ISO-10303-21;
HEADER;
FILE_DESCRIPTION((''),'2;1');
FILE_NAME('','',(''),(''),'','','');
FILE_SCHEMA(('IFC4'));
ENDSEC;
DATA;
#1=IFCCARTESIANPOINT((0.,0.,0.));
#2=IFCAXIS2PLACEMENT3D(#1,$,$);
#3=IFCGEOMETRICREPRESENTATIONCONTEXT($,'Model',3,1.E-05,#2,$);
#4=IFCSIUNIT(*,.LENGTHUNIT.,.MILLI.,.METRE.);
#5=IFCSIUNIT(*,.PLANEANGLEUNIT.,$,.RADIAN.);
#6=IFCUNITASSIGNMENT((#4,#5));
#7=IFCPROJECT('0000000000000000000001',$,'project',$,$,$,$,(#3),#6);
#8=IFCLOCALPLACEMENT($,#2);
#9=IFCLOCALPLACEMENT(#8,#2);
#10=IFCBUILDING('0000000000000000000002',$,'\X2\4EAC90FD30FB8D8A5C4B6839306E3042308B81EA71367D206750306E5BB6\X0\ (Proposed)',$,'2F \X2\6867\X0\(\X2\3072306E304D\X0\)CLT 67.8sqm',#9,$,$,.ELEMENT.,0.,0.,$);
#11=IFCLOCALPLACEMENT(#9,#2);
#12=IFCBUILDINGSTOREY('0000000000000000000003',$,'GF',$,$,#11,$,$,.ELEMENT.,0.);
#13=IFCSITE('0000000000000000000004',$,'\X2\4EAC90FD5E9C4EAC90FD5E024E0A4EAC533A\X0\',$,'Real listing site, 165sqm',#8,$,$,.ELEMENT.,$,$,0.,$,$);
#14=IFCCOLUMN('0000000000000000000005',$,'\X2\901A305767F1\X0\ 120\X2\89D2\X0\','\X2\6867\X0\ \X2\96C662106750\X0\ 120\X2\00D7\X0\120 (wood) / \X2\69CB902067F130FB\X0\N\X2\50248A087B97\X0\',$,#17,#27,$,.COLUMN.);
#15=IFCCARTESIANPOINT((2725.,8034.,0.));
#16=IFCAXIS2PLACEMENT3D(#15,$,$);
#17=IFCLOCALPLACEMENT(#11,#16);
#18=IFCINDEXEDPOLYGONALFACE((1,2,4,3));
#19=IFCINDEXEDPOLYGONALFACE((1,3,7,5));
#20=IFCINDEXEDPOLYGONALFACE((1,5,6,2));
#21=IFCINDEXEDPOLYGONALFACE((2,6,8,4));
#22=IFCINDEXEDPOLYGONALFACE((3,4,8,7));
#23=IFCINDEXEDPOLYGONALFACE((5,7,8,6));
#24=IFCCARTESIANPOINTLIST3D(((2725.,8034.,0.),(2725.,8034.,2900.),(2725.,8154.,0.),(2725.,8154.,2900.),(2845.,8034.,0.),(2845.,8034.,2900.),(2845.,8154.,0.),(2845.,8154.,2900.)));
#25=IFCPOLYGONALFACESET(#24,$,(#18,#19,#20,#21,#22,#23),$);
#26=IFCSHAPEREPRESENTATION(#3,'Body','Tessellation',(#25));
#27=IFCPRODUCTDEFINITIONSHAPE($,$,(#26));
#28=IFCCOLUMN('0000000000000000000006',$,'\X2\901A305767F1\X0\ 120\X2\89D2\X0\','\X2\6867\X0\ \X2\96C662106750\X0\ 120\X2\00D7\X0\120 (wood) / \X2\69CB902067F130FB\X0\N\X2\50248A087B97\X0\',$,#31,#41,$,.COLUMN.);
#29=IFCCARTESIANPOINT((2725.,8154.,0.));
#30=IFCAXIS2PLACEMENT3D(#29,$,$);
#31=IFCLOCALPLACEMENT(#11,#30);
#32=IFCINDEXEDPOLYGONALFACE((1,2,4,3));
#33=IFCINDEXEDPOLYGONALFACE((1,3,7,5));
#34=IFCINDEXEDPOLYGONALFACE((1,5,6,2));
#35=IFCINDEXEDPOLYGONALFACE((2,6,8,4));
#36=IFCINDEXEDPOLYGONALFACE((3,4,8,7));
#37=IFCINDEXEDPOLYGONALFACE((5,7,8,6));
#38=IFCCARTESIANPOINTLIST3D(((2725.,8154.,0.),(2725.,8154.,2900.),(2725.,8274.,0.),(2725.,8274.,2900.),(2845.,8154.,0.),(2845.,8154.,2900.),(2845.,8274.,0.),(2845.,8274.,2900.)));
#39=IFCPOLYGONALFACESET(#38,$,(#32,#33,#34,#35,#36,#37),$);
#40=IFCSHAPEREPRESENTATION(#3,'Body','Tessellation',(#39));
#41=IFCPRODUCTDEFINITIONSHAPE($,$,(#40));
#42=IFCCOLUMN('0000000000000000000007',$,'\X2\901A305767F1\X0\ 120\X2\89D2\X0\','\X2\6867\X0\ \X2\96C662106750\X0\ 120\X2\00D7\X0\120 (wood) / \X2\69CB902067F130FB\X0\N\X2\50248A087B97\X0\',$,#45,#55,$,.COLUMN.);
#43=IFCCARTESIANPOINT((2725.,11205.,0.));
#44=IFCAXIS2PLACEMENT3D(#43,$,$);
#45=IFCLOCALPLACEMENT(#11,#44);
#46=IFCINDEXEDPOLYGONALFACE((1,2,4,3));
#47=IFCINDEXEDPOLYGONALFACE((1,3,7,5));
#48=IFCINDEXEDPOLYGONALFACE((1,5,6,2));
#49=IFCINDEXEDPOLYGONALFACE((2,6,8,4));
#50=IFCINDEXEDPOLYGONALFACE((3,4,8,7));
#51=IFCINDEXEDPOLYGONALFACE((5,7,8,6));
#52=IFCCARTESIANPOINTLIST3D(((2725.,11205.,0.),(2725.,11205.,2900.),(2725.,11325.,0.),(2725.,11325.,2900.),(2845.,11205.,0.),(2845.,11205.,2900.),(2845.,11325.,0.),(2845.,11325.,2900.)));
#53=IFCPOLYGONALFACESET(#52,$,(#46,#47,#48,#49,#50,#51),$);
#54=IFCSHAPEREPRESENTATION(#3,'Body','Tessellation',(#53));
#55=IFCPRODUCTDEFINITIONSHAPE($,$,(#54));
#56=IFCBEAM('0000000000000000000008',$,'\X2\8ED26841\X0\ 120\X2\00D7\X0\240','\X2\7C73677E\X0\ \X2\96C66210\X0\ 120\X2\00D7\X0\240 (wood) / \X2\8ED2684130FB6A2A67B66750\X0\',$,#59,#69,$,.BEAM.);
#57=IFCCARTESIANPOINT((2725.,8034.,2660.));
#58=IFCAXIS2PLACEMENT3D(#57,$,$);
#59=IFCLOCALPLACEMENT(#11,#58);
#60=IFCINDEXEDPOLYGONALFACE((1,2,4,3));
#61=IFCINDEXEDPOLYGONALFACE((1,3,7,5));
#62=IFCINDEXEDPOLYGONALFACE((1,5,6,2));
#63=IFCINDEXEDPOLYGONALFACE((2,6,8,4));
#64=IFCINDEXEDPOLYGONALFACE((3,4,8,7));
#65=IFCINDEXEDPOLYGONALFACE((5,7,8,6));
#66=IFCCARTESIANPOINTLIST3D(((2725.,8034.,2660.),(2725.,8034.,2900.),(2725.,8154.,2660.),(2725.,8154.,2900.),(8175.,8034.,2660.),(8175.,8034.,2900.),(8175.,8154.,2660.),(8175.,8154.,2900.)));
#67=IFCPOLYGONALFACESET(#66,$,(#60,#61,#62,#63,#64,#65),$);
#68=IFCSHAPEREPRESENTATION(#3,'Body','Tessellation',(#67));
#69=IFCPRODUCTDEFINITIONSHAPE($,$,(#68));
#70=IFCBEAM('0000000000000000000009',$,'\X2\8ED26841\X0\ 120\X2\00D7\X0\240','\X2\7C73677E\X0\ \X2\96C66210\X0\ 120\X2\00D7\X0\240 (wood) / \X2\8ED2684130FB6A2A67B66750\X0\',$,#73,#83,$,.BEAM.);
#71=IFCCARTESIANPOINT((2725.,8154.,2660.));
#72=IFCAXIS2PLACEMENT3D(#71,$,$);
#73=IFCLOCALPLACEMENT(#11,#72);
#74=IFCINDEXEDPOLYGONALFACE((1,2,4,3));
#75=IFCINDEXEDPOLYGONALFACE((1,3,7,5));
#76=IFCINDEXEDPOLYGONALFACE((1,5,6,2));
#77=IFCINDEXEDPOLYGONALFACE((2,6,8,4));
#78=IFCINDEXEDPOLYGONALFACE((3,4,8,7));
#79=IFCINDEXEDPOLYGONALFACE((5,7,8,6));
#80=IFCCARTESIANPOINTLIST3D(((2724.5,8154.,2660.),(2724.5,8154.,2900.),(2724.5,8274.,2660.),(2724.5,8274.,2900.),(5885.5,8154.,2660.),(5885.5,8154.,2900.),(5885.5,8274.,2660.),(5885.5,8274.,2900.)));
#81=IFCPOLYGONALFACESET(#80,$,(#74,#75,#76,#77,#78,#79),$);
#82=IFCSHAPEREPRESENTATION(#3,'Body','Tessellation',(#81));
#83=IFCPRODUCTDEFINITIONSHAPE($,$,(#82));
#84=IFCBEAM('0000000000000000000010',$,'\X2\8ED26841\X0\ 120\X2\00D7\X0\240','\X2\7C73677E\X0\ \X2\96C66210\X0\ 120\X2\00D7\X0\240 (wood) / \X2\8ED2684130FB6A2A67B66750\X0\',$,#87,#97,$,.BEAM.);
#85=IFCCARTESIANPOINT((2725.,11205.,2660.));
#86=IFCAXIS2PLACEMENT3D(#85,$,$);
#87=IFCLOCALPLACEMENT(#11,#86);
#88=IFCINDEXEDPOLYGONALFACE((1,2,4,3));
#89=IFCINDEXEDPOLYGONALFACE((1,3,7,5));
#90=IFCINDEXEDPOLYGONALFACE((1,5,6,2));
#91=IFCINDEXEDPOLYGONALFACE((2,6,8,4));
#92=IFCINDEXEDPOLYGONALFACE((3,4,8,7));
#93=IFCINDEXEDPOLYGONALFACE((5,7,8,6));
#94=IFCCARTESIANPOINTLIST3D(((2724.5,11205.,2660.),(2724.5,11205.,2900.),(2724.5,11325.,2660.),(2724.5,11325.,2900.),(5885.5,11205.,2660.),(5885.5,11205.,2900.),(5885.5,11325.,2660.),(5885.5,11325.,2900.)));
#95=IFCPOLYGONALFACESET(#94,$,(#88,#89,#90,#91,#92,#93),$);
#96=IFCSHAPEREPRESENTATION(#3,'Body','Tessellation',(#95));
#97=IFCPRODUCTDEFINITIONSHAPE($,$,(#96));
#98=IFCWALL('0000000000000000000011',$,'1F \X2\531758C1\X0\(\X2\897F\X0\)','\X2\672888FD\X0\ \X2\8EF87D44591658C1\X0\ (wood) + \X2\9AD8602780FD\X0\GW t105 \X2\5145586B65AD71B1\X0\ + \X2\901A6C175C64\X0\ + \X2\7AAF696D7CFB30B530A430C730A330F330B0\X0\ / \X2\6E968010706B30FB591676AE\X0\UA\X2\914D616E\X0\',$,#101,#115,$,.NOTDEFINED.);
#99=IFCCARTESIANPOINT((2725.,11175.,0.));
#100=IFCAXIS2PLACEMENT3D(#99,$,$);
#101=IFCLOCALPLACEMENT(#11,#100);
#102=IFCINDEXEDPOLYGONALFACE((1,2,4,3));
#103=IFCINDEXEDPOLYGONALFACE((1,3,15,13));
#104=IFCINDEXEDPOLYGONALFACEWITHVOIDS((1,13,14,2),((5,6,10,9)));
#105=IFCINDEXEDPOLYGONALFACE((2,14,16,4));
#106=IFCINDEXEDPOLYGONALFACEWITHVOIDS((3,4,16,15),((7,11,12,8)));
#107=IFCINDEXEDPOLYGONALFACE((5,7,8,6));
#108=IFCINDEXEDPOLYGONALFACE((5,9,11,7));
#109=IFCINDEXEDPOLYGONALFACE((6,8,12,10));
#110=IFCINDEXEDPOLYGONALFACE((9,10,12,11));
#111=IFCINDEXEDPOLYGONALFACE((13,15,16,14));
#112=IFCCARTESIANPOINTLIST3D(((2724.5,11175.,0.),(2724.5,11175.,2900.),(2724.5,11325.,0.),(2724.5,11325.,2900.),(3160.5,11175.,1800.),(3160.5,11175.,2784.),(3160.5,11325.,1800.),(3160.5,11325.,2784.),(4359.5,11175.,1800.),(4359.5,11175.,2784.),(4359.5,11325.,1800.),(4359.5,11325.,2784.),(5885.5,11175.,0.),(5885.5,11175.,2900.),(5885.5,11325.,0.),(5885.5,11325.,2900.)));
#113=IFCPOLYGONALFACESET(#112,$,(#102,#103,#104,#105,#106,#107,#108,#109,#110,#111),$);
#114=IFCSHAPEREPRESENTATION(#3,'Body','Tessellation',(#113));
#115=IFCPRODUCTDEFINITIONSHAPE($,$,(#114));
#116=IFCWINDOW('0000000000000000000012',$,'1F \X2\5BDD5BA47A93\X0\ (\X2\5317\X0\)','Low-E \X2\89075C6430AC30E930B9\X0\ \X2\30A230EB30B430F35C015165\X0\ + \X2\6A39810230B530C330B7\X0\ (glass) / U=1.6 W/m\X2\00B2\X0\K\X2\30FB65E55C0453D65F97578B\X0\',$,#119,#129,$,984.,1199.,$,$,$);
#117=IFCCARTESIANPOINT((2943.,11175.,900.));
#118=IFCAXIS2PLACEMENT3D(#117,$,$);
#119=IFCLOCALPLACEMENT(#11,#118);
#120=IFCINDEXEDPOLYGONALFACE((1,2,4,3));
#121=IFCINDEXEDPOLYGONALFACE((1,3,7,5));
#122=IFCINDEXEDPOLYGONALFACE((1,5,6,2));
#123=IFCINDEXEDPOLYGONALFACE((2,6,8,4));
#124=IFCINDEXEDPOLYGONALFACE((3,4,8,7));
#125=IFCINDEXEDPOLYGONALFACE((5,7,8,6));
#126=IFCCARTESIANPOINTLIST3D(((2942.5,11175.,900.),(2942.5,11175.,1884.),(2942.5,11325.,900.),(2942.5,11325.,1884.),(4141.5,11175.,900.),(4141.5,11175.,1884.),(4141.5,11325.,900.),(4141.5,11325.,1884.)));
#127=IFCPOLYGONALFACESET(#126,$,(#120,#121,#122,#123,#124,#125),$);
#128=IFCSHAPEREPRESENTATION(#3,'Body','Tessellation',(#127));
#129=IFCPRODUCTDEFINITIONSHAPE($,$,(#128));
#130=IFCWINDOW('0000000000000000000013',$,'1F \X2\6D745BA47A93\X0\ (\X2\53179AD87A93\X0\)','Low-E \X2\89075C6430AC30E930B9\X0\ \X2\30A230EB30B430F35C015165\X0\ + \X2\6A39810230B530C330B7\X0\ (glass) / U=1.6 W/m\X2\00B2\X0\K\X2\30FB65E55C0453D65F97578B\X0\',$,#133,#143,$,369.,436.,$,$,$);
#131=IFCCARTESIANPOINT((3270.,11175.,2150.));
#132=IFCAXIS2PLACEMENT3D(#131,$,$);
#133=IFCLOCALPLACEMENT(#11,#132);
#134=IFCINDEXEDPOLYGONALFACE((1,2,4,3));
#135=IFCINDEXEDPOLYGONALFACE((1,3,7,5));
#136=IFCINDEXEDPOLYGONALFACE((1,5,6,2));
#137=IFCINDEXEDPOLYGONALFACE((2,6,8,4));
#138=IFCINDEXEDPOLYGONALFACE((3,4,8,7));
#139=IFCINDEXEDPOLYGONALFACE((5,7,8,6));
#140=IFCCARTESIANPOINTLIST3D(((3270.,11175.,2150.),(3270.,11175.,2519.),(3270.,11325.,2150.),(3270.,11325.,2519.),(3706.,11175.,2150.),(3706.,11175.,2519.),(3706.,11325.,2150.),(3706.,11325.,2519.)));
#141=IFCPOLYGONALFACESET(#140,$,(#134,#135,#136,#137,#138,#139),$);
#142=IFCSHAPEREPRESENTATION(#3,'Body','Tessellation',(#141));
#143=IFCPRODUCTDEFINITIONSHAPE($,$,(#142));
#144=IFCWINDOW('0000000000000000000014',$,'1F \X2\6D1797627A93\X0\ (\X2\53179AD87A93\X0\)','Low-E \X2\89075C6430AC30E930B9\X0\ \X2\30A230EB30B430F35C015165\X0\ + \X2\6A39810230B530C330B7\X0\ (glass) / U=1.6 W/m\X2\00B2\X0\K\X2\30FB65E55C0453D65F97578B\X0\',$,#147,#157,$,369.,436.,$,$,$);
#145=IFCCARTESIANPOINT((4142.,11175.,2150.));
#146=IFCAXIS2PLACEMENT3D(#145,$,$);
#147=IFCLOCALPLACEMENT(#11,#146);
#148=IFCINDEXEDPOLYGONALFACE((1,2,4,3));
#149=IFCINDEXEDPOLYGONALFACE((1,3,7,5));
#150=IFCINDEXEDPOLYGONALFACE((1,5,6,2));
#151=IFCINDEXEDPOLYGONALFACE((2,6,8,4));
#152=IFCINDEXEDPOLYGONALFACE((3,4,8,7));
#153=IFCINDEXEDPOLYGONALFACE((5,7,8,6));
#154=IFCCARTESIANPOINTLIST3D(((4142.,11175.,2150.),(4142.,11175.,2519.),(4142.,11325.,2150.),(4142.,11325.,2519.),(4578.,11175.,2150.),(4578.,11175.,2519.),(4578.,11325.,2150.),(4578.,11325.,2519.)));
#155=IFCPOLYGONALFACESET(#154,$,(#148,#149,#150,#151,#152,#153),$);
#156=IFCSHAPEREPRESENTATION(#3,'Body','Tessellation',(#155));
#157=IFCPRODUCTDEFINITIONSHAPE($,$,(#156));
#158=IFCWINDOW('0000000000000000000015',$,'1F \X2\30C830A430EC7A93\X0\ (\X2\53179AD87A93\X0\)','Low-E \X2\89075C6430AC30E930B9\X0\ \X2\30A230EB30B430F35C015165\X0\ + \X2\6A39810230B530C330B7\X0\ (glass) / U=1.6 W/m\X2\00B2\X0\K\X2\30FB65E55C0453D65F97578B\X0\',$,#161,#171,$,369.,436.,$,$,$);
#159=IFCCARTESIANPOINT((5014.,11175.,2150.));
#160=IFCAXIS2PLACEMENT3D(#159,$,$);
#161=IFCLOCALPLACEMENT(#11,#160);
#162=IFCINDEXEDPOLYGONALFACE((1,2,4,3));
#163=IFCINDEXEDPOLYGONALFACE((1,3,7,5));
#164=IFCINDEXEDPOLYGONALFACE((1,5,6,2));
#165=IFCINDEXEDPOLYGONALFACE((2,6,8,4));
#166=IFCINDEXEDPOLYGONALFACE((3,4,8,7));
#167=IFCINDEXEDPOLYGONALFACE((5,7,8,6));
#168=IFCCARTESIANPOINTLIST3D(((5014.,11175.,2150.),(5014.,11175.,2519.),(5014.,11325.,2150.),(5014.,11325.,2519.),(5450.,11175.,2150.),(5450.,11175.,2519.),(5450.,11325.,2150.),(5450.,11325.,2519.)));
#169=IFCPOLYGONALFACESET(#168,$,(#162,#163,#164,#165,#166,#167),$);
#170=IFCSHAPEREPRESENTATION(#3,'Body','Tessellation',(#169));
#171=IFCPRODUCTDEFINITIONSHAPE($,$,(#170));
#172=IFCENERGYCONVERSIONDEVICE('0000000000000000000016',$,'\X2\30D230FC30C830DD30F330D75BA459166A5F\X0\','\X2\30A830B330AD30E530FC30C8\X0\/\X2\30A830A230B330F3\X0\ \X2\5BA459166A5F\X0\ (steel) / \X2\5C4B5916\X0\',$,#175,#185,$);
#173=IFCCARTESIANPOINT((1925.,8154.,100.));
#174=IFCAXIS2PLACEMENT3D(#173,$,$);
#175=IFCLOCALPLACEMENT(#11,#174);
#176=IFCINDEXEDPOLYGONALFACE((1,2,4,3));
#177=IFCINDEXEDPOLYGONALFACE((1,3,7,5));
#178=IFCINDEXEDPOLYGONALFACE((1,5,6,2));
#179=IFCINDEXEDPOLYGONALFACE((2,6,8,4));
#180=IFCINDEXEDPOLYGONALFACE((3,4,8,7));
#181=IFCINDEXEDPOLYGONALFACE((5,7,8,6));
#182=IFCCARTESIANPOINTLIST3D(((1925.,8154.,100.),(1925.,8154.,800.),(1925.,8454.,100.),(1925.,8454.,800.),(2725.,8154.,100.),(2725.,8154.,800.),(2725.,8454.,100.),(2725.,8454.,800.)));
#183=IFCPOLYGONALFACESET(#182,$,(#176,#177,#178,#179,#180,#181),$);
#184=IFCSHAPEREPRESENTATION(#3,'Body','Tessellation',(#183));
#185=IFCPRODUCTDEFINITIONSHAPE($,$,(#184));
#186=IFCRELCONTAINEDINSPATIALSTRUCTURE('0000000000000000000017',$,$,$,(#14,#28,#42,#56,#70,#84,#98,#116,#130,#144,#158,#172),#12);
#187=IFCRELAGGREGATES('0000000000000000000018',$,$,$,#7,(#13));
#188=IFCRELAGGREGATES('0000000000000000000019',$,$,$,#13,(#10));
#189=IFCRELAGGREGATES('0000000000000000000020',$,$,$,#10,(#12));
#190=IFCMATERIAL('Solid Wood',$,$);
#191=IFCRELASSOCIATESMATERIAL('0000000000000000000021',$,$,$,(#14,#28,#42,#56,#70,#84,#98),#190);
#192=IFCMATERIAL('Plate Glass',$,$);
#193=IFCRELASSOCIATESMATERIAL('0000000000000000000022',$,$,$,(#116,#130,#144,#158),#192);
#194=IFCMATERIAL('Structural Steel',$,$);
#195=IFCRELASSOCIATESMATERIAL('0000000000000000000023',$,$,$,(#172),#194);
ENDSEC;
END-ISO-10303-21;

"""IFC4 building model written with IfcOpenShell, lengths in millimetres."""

from ifc_helpers import new_model, si_unit, frame, frame_2d, origin, place, context, project, spatial, rectangle, extrude, material, element, fill, save


model = new_model("IFC4")

# Units and contexts
model_context = context("Model", 3, precision=1e-05, world=origin())
ifc_project = project(units=[si_unit("LENGTHUNIT", "METRE", prefix="MILLI"), si_unit("PLANEANGLEUNIT", "RADIAN")], contexts=[model_context])

# Site, building, storey
site_placement = place(None, origin())
site = spatial("IfcSite", under=ifc_project, at=site_placement, Name="京都府京都市上京区", ObjectType="Real listing site, 165sqm", CompositionType="ELEMENT", RefElevation=0.0)
building_placement = place(site_placement, origin())
building = spatial("IfcBuilding", under=site, at=building_placement, Name="京都・越屋根のある自然素材の家 (Proposed)", ObjectType="2F 桧(ひのき)CLT 67.8sqm", CompositionType="ELEMENT", ElevationOfRefHeight=0.0, ElevationOfTerrain=0.0)
storey_placement = place(building_placement, origin())
storey = spatial("IfcBuildingStorey", under=building, at=storey_placement, Name="GF", CompositionType="ELEMENT", Elevation=0.0)

# Columns
ifc_material_1 = material(Name="Solid Wood")
column_1_placement = place(storey_placement, frame((2725.0, 8034.0, 0.0)))
element("IfcColumn", 1, at=column_1_placement, inside=storey, material=ifc_material_1, Name="通し柱 120角", Description="桧 集成材 120×120 (wood) / 構造柱・N値計算", PredefinedType="COLUMN", context=model_context, shape_type="SweptSolid", body=[
    extrude(rectangle(XDim=120.0, YDim=120.0, at=frame_2d((60.0, 60.0))), frame((2725.0, 8034.0, 0.0)), (0.0, 0.0, 1.0), 2900.0),
])
column_2_placement = place(storey_placement, frame((2725.0, 8154.0, 0.0)))
element("IfcColumn", 2, at=column_2_placement, inside=storey, material=ifc_material_1, Name="通し柱 120角", Description="桧 集成材 120×120 (wood) / 構造柱・N値計算", PredefinedType="COLUMN", context=model_context, shape_type="SweptSolid", body=[
    extrude(rectangle(XDim=120.0, YDim=120.0, at=frame_2d((60.0, 60.0))), frame((2725.0, 8154.0, 0.0)), (0.0, 0.0, 1.0), 2900.0),
])
column_3_placement = place(storey_placement, frame((2725.0, 11205.0, 0.0)))
element("IfcColumn", 3, at=column_3_placement, inside=storey, material=ifc_material_1, Name="通し柱 120角", Description="桧 集成材 120×120 (wood) / 構造柱・N値計算", PredefinedType="COLUMN", context=model_context, shape_type="SweptSolid", body=[
    extrude(rectangle(XDim=120.0, YDim=120.0, at=frame_2d((60.0, 60.0))), frame((2725.0, 11205.0, 0.0)), (0.0, 0.0, 1.0), 2900.0),
])

# Beams
beam_1_placement = place(storey_placement, frame((2725.0, 8034.0, 2660.0)))
element("IfcBeam", 4, at=beam_1_placement, inside=storey, material=ifc_material_1, Name="軒桁 120×240", Description="米松 集成 120×240 (wood) / 軒桁・横架材", PredefinedType="BEAM", context=model_context, shape_type="SweptSolid", body=[
    extrude(rectangle(XDim=5450.0, YDim=120.0, at=frame_2d((2725.0, 60.0))), frame((2725.0, 8034.0, 2660.0)), (0.0, 0.0, 1.0), 240.0),
])
beam_2_placement = place(storey_placement, frame((2725.0, 8154.0, 2660.0)))
element("IfcBeam", 5, at=beam_2_placement, inside=storey, material=ifc_material_1, Name="軒桁 120×240", Description="米松 集成 120×240 (wood) / 軒桁・横架材", PredefinedType="BEAM", context=model_context, shape_type="SweptSolid", body=[
    extrude(rectangle(XDim=3161.0, YDim=120.0, at=frame_2d((1580.0, 60.0))), frame((2725.0, 8154.0, 2660.0)), (0.0, 0.0, 1.0), 240.0),
])
beam_3_placement = place(storey_placement, frame((2725.0, 11205.0, 2660.0)))
element("IfcBeam", 6, at=beam_3_placement, inside=storey, material=ifc_material_1, Name="軒桁 120×240", Description="米松 集成 120×240 (wood) / 軒桁・横架材", PredefinedType="BEAM", context=model_context, shape_type="SweptSolid", body=[
    extrude(rectangle(XDim=3161.0, YDim=120.0, at=frame_2d((1580.0, 60.0))), frame((2725.0, 11205.0, 2660.0)), (0.0, 0.0, 1.0), 240.0),
])

# Wall, openings, windows
wall_1_placement = place(storey_placement, frame((2725.0, 11175.0, 0.0)))
wall_1 = element("IfcWall", 7, at=wall_1_placement, inside=storey, material=ifc_material_1, Name="1F 北壁(西)", Description="木製 軸組外壁 (wood) + 高性能GW t105 充填断熱 + 通気層 + 窯業系サイディング / 準耐火・外皮UA配慮", PredefinedType="NOTDEFINED", context=model_context, shape_type="SweptSolid", body=[
    extrude(rectangle(XDim=3161.0, YDim=150.0, at=frame_2d((1580.0, 75.0))), frame((2725.0, 11175.0, 0.0)), (0.0, 0.0, 1.0), 2900.0),
])
opening_1_placement = place(storey_placement, frame((2943.0, 11175.0, 900.0)))
opening_1 = element("IfcOpeningElement", 8, at=opening_1_placement, cuts=wall_1, PredefinedType="NOTDEFINED", context=model_context, shape_type="SweptSolid", body=[
    extrude(rectangle(XDim=1199.0, YDim=150.0, at=frame_2d((599.0, 75.0))), frame((2943.0, 11175.0, 900.0)), (0.0, 0.0, 1.0), 984.0),
])
opening_2_placement = place(storey_placement, frame((3270.0, 11175.0, 2150.0)))
opening_2 = element("IfcOpeningElement", 9, at=opening_2_placement, cuts=wall_1, PredefinedType="NOTDEFINED", context=model_context, shape_type="SweptSolid", body=[
    extrude(rectangle(XDim=436.0, YDim=150.0, at=frame_2d((218.0, 75.0))), frame((3270.0, 11175.0, 2150.0)), (0.0, 0.0, 1.0), 369.0),
])
opening_3_placement = place(storey_placement, frame((4142.0, 11175.0, 2150.0)))
opening_3 = element("IfcOpeningElement", 10, at=opening_3_placement, cuts=wall_1, PredefinedType="NOTDEFINED", context=model_context, shape_type="SweptSolid", body=[
    extrude(rectangle(XDim=436.0, YDim=150.0, at=frame_2d((218.0, 75.0))), frame((4142.0, 11175.0, 2150.0)), (0.0, 0.0, 1.0), 369.0),
])
opening_4_placement = place(storey_placement, frame((5014.0, 11175.0, 2150.0)))
opening_4 = element("IfcOpeningElement", 11, at=opening_4_placement, cuts=wall_1, PredefinedType="NOTDEFINED", context=model_context, shape_type="SweptSolid", body=[
    extrude(rectangle(XDim=436.0, YDim=150.0, at=frame_2d((218.0, 75.0))), frame((5014.0, 11175.0, 2150.0)), (0.0, 0.0, 1.0), 369.0),
])
ifc_material_2 = material(Name="Plate Glass")
window_1_placement = place(storey_placement, frame((2943.0, 11175.0, 900.0)))
window_1 = element("IfcWindow", 12, at=window_1_placement, inside=storey, material=ifc_material_2, Name="1F 寝室窓 (北)", Description="Low-E 複層ガラス アルゴン封入 + 樹脂サッシ (glass) / U=1.6 W/m²K・日射取得型", OverallHeight=984.0, OverallWidth=1199.0, context=model_context, shape_type="SweptSolid", body=[
    extrude(rectangle(XDim=1199.0, YDim=150.0, at=frame_2d((599.0, 75.0))), frame((2943.0, 11175.0, 900.0)), (0.0, 0.0, 1.0), 984.0),
])
fill(opening_1, window_1)
window_2_placement = place(storey_placement, frame((3270.0, 11175.0, 2150.0)))
window_2 = element("IfcWindow", 13, at=window_2_placement, inside=storey, material=ifc_material_2, Name="1F 浴室窓 (北高窓)", Description="Low-E 複層ガラス アルゴン封入 + 樹脂サッシ (glass) / U=1.6 W/m²K・日射取得型", OverallHeight=369.0, OverallWidth=436.0, context=model_context, shape_type="SweptSolid", body=[
    extrude(rectangle(XDim=436.0, YDim=150.0, at=frame_2d((218.0, 75.0))), frame((3270.0, 11175.0, 2150.0)), (0.0, 0.0, 1.0), 369.0),
])
fill(opening_2, window_2)
window_3_placement = place(storey_placement, frame((4142.0, 11175.0, 2150.0)))
window_3 = element("IfcWindow", 14, at=window_3_placement, inside=storey, material=ifc_material_2, Name="1F 洗面窓 (北高窓)", Description="Low-E 複層ガラス アルゴン封入 + 樹脂サッシ (glass) / U=1.6 W/m²K・日射取得型", OverallHeight=369.0, OverallWidth=436.0, context=model_context, shape_type="SweptSolid", body=[
    extrude(rectangle(XDim=436.0, YDim=150.0, at=frame_2d((218.0, 75.0))), frame((4142.0, 11175.0, 2150.0)), (0.0, 0.0, 1.0), 369.0),
])
fill(opening_3, window_3)
window_4_placement = place(storey_placement, frame((5014.0, 11175.0, 2150.0)))
window_4 = element("IfcWindow", 15, at=window_4_placement, inside=storey, material=ifc_material_2, Name="1F トイレ窓 (北高窓)", Description="Low-E 複層ガラス アルゴン封入 + 樹脂サッシ (glass) / U=1.6 W/m²K・日射取得型", OverallHeight=369.0, OverallWidth=436.0, context=model_context, shape_type="SweptSolid", body=[
    extrude(rectangle(XDim=436.0, YDim=150.0, at=frame_2d((218.0, 75.0))), frame((5014.0, 11175.0, 2150.0)), (0.0, 0.0, 1.0), 369.0),
])
fill(opening_4, window_4)

# Energy conversion device
ifc_material_3 = material(Name="Structural Steel")
energy_conversion_device_placement = place(storey_placement, frame((1925.0, 8154.0, 100.0)))
element("IfcEnergyConversionDevice", 16, at=energy_conversion_device_placement, inside=storey, material=ifc_material_3, Name="ヒートポンプ室外機", Description="エコキュート/エアコン 室外機 (steel) / 屋外", context=model_context, shape_type="SweptSolid", body=[
    extrude(rectangle(XDim=800.0, YDim=300.0, at=frame_2d((400.0, 150.0))), frame((1925.0, 8154.0, 100.0)), (0.0, 0.0, 1.0), 700.0),
])

save(model, "model.ifc")
